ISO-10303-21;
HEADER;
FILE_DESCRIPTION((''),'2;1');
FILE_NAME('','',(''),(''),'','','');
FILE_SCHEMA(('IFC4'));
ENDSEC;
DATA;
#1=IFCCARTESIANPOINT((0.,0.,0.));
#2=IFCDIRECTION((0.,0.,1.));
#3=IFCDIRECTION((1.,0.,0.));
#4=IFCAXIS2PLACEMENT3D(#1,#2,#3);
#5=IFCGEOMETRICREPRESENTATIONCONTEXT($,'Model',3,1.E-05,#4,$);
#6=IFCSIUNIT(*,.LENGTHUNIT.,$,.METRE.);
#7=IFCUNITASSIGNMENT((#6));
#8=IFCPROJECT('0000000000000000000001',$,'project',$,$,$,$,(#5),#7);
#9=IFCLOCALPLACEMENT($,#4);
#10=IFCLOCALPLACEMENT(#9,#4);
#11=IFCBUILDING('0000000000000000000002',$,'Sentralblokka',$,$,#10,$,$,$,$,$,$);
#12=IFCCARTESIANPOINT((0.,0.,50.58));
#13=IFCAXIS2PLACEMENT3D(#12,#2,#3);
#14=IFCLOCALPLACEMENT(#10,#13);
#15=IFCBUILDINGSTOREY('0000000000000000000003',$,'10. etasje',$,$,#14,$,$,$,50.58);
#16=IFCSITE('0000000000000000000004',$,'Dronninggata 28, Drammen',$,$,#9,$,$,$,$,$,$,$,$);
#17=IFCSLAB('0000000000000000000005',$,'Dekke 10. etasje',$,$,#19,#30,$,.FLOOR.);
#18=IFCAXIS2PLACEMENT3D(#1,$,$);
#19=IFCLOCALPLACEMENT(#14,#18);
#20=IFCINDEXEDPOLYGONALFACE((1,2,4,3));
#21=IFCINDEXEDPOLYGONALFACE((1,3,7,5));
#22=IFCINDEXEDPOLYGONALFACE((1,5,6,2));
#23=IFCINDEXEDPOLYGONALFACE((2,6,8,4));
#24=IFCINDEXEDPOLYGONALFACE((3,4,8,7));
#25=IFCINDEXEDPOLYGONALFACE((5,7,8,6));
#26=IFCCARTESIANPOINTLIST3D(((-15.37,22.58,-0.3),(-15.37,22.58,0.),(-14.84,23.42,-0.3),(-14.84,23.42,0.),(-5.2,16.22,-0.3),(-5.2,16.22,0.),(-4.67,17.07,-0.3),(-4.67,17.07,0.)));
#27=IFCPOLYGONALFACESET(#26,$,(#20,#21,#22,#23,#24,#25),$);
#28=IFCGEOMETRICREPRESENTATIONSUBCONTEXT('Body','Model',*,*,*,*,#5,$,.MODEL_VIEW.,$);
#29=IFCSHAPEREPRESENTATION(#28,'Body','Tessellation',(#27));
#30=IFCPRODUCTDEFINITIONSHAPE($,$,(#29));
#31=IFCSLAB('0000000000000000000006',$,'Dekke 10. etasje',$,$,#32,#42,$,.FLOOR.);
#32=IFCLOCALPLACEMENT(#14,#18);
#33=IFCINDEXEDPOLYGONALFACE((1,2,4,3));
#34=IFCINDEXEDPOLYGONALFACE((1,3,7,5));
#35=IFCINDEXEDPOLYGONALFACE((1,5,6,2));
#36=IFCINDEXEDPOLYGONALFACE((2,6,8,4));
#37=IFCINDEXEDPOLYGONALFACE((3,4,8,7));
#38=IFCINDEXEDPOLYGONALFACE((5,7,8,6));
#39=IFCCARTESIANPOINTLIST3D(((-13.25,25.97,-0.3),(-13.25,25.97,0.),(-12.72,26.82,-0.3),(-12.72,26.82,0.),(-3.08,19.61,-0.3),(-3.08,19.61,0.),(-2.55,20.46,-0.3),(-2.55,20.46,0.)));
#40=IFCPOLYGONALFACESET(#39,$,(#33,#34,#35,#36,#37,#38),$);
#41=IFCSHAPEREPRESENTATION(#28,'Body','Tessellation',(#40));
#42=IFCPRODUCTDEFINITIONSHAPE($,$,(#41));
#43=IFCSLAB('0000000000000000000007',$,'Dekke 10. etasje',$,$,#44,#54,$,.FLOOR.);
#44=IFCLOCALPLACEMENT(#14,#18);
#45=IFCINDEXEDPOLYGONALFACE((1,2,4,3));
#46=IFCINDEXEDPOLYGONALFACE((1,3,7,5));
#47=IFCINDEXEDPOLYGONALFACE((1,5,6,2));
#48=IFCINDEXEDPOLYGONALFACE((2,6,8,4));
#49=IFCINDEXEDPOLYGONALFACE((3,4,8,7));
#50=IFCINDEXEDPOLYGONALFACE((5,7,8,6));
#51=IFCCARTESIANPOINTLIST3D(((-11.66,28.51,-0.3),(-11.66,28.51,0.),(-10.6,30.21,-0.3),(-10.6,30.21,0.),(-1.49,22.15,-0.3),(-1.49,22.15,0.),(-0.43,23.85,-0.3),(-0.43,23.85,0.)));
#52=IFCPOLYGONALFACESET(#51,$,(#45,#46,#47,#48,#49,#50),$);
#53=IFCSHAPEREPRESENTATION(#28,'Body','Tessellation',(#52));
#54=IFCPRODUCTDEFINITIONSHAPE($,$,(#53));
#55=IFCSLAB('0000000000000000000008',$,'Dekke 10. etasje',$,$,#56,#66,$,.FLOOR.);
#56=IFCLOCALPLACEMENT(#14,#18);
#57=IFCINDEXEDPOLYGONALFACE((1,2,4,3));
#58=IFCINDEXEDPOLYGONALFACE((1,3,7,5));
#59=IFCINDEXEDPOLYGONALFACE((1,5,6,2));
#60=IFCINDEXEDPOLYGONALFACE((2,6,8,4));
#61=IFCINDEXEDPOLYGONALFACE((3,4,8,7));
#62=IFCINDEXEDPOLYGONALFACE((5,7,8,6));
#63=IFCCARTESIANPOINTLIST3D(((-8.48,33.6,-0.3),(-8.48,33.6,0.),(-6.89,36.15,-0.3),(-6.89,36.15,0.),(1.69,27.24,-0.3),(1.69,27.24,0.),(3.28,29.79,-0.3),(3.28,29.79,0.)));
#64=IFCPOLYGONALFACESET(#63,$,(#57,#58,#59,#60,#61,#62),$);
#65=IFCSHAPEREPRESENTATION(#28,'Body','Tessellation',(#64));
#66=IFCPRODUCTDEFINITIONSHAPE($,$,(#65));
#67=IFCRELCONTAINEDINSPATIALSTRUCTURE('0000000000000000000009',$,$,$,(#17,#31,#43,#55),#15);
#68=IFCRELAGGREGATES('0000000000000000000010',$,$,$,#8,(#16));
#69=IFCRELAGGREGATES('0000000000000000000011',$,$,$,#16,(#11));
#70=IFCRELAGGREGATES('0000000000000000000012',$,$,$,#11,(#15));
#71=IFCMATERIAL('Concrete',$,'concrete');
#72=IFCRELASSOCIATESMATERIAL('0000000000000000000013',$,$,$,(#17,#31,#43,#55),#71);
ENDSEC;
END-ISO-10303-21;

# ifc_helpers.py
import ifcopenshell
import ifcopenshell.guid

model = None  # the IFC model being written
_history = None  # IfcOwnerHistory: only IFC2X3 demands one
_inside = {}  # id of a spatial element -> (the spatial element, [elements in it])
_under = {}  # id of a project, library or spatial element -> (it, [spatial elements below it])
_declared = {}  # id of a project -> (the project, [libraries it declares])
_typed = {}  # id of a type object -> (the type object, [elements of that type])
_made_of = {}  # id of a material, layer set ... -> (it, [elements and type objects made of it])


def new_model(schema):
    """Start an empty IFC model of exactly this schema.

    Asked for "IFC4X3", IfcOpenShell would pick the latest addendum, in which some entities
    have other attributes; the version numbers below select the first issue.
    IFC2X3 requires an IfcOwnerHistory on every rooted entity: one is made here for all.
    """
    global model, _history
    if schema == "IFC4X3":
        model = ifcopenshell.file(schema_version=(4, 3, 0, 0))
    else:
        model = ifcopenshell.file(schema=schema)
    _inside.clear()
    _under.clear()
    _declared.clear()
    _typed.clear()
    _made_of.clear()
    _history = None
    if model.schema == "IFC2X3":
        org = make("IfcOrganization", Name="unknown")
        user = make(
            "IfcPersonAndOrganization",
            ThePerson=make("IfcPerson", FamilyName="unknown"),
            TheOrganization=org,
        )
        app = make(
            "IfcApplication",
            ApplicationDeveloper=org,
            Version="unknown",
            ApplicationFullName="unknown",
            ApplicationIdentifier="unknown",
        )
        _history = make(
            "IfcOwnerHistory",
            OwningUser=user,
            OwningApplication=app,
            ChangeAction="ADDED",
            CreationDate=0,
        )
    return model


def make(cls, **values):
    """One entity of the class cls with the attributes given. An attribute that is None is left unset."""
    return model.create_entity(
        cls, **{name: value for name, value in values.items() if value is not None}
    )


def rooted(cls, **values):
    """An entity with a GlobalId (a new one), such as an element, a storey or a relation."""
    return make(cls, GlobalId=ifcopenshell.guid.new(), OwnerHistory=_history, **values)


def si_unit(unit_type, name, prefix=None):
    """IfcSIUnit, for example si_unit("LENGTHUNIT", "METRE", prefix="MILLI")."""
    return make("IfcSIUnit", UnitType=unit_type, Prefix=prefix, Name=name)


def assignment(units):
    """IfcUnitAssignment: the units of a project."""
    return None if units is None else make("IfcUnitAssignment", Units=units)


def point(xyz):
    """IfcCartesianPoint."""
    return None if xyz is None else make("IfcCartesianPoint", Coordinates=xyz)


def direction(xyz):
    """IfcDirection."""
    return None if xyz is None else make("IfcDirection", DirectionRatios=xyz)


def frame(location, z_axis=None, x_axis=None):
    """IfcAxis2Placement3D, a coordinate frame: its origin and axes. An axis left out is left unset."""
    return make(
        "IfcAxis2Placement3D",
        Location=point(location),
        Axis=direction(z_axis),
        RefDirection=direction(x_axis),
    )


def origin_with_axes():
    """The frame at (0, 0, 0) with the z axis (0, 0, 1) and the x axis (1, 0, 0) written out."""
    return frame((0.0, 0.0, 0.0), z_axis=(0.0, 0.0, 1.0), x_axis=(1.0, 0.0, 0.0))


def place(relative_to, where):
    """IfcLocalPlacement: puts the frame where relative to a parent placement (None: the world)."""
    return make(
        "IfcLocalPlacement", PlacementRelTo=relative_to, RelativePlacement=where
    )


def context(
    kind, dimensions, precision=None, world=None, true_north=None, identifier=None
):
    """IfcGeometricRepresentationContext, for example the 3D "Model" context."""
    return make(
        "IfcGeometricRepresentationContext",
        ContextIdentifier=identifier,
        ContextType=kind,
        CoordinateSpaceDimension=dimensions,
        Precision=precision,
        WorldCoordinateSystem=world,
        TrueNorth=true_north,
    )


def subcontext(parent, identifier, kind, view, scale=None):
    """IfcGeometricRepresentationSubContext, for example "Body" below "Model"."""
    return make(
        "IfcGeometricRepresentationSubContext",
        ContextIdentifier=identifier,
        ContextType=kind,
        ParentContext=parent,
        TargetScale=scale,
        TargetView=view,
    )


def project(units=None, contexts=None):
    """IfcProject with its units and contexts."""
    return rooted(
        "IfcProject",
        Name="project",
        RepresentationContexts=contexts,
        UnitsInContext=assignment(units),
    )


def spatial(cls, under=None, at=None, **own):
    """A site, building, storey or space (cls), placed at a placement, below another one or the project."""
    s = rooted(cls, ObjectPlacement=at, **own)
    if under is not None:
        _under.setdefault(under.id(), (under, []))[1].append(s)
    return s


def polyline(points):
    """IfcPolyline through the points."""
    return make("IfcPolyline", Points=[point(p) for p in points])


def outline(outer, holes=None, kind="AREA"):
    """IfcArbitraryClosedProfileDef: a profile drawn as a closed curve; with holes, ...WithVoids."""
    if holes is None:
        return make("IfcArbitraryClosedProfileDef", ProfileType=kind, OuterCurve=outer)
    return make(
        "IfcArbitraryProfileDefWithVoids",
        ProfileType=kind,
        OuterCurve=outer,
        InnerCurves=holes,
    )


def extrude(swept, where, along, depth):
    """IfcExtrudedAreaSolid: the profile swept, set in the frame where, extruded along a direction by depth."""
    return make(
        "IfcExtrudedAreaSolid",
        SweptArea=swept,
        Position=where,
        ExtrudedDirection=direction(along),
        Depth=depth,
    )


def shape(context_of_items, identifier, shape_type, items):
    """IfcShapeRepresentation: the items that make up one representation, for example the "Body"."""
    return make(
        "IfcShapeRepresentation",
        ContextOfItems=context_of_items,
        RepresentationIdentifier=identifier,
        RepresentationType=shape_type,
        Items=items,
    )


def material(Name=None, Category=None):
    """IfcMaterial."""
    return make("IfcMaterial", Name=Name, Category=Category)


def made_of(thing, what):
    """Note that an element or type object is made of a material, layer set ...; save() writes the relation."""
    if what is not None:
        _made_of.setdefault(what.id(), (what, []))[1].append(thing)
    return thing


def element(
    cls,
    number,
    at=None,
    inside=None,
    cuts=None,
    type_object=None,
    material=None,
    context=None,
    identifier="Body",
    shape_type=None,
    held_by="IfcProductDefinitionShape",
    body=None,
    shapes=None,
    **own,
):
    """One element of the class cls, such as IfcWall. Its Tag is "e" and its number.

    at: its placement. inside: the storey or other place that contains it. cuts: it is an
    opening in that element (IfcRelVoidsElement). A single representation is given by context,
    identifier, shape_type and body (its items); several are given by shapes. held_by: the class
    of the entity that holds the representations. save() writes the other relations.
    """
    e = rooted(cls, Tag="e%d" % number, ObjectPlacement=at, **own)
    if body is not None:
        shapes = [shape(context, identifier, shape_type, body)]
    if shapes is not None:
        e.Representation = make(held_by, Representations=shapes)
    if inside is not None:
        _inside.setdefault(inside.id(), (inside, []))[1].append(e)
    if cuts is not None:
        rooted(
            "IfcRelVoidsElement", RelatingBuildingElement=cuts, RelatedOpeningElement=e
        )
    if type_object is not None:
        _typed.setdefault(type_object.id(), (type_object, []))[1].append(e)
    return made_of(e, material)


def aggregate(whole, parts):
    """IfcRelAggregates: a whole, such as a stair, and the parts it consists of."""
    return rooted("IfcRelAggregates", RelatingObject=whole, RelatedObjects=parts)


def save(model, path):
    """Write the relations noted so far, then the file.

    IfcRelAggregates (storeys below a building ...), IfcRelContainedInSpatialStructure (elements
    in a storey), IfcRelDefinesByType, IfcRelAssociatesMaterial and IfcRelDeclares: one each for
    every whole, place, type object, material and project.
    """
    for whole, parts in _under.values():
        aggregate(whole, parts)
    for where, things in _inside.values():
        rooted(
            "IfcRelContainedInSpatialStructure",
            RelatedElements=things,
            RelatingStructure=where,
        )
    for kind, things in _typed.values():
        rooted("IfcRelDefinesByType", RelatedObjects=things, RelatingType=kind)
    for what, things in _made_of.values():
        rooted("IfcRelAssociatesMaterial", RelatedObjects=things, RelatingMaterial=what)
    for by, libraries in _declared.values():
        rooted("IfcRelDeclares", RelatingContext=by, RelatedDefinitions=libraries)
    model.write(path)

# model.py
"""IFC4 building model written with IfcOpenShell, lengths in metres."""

from ifc_helpers import new_model, si_unit, frame, origin_with_axes, place, context, subcontext, project, spatial, polyline, outline, extrude, material, element, save


model = new_model("IFC4")

# Units and contexts
model_context = context("Model", 3, precision=1e-05, world=origin_with_axes())
body_context = subcontext(model_context, "Body", "Model", "MODEL_VIEW")
ifc_project = project(units=[si_unit("LENGTHUNIT", "METRE")], contexts=[model_context])

# Site, building, storey
site_placement = place(None, origin_with_axes())
site = spatial("IfcSite", under=ifc_project, at=site_placement, Name="Dronninggata 28, Drammen")
building_placement = place(site_placement, origin_with_axes())
building = spatial("IfcBuilding", under=site, at=building_placement, Name="Sentralblokka")
storey_placement = place(building_placement, frame((0.0, 0.0, 50.58), z_axis=(0.0, 0.0, 1.0), x_axis=(1.0, 0.0, 0.0)))
storey = spatial("IfcBuildingStorey", under=building, at=storey_placement, Name="10. etasje", Elevation=50.58)

# Slabs
ifc_material = material(Name="Concrete", Category="concrete")
slab_1_placement = place(storey_placement, frame((0.0, 0.0, -50.58), z_axis=(0.0, 0.0, 1.0), x_axis=(1.0, 0.0, 0.0)))
element("IfcSlab", 1, at=slab_1_placement, inside=storey, material=ifc_material, Name="Dekke 10. etasje", PredefinedType="FLOOR", context=body_context, shape_type="SweptSolid", body=[
    extrude(outline(polyline([(-5.2, 16.22), (-4.67, 17.07), (-14.84, 23.42), (-15.37, 22.58), (-5.2, 16.22)])), frame((0.0, 0.0, 50.28)), (0.0, 0.0, 1.0), 0.3),
])
slab_2_placement = place(storey_placement, frame((0.0, 0.0, -50.58), z_axis=(0.0, 0.0, 1.0), x_axis=(1.0, 0.0, 0.0)))
element("IfcSlab", 2, at=slab_2_placement, inside=storey, material=ifc_material, Name="Dekke 10. etasje", PredefinedType="FLOOR", context=body_context, shape_type="SweptSolid", body=[
    extrude(outline(polyline([(-3.08, 19.61), (-2.55, 20.46), (-12.72, 26.82), (-13.25, 25.97), (-3.08, 19.61)])), frame((0.0, 0.0, 50.28)), (0.0, 0.0, 1.0), 0.3),
])
slab_3_placement = place(storey_placement, frame((0.0, 0.0, -50.58), z_axis=(0.0, 0.0, 1.0), x_axis=(1.0, 0.0, 0.0)))
element("IfcSlab", 3, at=slab_3_placement, inside=storey, material=ifc_material, Name="Dekke 10. etasje", PredefinedType="FLOOR", context=body_context, shape_type="SweptSolid", body=[
    extrude(outline(polyline([(-1.49, 22.15), (-0.43, 23.85), (-10.6, 30.21), (-11.66, 28.51), (-1.49, 22.15)])), frame((0.0, 0.0, 50.28)), (0.0, 0.0, 1.0), 0.3),
])
slab_4_placement = place(storey_placement, frame((0.0, 0.0, -50.58), z_axis=(0.0, 0.0, 1.0), x_axis=(1.0, 0.0, 0.0)))
element("IfcSlab", 4, at=slab_4_placement, inside=storey, material=ifc_material, Name="Dekke 10. etasje", PredefinedType="FLOOR", context=body_context, shape_type="SweptSolid", body=[
    extrude(outline(polyline([(1.69, 27.24), (3.28, 29.79), (-6.89, 36.15), (-8.48, 33.6), (1.69, 27.24)])), frame((0.0, 0.0, 50.28)), (0.0, 0.0, 1.0), 0.3),
])

save(model, "model.ifc")
